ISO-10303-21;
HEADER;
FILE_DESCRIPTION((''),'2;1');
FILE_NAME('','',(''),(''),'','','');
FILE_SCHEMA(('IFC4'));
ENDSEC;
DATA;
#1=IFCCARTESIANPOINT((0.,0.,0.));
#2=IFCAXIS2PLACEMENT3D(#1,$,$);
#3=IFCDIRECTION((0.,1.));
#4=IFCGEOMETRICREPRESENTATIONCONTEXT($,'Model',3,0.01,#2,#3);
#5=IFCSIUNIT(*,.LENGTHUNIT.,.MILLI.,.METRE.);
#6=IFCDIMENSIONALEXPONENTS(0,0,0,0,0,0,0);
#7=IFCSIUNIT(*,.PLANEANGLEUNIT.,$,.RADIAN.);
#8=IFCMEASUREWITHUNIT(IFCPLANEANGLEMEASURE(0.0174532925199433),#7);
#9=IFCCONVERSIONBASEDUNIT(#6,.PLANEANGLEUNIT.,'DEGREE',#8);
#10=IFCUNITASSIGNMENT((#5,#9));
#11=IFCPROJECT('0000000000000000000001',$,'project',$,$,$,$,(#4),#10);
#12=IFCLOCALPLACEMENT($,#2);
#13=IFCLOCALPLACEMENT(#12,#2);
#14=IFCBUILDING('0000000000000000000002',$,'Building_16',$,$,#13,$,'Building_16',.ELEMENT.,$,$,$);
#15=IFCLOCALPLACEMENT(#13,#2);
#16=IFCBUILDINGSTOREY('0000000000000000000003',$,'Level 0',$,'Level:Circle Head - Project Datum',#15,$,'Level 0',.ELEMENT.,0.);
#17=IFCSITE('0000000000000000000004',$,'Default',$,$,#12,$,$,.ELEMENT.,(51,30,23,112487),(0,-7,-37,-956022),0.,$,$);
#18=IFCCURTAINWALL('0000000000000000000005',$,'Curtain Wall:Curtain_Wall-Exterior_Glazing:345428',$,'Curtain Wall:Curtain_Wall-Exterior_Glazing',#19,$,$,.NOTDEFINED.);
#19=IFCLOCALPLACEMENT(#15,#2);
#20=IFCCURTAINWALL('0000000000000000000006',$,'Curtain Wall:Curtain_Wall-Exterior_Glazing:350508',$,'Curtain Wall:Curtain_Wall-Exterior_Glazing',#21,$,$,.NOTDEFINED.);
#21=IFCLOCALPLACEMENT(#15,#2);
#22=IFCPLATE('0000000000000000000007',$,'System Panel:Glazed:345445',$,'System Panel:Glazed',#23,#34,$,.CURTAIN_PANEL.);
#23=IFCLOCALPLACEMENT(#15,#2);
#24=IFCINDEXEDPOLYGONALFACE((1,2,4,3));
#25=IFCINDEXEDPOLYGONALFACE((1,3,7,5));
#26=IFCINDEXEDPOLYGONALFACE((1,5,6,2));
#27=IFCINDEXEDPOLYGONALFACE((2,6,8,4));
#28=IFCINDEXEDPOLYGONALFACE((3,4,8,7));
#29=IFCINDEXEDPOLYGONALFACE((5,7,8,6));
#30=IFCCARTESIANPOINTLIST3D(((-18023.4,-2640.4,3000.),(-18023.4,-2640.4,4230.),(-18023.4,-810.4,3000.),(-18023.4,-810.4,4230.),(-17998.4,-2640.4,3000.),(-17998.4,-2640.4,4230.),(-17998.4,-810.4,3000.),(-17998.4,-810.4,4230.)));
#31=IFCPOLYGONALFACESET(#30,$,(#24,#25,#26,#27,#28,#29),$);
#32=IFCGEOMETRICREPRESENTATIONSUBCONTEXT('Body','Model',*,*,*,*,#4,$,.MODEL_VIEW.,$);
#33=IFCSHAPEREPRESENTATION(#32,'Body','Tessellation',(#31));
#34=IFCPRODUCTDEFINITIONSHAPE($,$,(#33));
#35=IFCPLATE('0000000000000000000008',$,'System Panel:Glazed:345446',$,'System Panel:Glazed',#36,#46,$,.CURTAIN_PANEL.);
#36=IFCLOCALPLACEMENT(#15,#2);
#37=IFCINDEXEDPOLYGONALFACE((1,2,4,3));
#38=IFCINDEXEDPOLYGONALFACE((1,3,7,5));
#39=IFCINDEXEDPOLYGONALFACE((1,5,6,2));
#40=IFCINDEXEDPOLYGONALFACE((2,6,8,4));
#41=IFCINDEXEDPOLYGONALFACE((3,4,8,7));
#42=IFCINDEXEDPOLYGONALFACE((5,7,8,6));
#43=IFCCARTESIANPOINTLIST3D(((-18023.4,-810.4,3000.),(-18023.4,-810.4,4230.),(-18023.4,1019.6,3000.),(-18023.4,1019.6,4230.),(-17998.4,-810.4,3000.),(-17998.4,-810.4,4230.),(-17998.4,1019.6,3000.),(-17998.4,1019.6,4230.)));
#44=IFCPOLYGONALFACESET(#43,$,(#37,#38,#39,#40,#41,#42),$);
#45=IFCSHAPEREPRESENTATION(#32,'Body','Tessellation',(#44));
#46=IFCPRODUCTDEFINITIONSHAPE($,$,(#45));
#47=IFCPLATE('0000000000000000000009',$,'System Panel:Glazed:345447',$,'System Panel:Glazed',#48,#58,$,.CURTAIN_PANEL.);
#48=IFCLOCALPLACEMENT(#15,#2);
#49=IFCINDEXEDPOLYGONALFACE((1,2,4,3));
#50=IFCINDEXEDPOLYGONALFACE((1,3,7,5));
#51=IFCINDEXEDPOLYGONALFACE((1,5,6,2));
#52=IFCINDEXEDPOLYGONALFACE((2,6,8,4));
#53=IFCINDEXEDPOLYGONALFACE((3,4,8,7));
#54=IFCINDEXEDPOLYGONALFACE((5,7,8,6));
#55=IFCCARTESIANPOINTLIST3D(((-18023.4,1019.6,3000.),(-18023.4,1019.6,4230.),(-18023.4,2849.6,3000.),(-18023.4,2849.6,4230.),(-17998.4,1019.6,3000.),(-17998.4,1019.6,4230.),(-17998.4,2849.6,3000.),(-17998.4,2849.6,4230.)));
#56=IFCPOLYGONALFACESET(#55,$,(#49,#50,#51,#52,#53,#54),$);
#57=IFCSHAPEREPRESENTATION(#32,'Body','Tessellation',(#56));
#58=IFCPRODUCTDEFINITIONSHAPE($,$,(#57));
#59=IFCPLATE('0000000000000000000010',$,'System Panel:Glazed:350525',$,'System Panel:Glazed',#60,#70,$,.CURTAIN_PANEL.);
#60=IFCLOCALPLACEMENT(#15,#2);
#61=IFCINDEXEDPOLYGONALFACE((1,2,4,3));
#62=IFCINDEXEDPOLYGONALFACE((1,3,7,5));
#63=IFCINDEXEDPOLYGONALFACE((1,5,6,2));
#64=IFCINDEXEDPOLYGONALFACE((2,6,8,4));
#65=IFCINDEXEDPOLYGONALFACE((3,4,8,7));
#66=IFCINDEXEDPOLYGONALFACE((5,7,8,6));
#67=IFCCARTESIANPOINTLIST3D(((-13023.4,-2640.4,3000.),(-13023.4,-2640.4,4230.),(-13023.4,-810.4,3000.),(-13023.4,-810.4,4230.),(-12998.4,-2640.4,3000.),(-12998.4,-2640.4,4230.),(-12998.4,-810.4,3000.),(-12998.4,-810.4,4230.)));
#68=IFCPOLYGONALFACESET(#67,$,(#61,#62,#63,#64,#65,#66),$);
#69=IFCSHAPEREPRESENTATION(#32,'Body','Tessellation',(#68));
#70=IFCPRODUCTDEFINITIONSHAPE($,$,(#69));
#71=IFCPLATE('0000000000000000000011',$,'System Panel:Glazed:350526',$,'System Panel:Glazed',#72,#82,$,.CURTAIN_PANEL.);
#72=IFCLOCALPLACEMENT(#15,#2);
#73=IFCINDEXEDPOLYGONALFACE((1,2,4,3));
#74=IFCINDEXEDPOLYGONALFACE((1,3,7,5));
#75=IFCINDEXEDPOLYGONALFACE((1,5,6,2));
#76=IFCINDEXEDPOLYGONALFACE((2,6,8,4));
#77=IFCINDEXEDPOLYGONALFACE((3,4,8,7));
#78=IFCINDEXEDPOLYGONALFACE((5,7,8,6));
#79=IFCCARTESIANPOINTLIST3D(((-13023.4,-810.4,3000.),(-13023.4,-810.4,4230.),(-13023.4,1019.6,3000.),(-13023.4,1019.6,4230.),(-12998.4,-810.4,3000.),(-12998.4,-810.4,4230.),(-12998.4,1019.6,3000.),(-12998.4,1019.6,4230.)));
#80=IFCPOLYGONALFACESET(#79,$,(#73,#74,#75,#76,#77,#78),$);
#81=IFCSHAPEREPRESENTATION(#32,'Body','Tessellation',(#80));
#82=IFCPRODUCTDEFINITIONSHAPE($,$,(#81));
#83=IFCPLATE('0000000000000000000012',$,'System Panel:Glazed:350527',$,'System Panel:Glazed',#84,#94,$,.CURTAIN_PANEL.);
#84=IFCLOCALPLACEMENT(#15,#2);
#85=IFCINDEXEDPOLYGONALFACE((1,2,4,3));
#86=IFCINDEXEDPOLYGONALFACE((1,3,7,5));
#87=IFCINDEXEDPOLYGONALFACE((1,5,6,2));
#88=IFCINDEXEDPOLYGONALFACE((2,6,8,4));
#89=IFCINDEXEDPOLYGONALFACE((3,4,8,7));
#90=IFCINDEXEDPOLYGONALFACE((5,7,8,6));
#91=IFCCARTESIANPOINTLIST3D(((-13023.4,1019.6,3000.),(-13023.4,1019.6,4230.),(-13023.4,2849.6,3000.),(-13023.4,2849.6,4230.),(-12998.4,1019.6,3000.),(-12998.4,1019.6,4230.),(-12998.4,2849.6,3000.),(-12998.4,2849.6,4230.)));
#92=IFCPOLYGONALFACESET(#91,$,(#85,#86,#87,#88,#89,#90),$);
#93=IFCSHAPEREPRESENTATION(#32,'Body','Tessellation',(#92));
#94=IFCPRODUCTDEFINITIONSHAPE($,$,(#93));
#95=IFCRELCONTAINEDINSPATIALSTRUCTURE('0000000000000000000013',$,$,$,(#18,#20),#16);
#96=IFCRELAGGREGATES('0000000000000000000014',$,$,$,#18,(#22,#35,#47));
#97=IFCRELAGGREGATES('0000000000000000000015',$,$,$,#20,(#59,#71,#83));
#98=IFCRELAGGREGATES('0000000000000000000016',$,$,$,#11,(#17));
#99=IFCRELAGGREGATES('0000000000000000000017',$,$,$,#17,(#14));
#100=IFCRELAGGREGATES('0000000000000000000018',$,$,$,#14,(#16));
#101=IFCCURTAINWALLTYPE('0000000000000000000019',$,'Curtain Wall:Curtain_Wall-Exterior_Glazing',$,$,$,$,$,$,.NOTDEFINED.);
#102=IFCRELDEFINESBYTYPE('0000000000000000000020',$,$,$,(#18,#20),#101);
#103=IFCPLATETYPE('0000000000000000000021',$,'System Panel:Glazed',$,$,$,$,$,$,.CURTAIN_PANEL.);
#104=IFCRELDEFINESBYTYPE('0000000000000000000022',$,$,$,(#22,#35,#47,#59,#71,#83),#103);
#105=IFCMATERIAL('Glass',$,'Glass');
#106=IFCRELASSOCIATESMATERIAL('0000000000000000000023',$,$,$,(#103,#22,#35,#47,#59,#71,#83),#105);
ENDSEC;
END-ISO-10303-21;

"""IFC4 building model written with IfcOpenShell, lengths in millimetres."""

from ifc_helpers import new_model, entity, si_unit, converted_unit, direction, frame, origin, place, context, subcontext, project, spatial, indexed_curve, outline, extrude, source, transform, mapped, material, type_object, type_shapes, element, aggregate, save


model = new_model("IFC4")

# Units and contexts
model_context = context("Model", 3, precision=0.01, world=origin(), true_north=direction((0.0, 1.0)))
body_context = subcontext(model_context, "Body", "Model", "MODEL_VIEW")
ifc_project = project(units=[si_unit("LENGTHUNIT", "METRE", prefix="MILLI"), converted_unit("PLANEANGLEUNIT", "DEGREE", entity("IfcPlaneAngleMeasure", 0.0174532925199433), si_unit("PLANEANGLEUNIT", "RADIAN"), dimensions=[0, 0, 0, 0, 0, 0, 0])], contexts=[model_context])

# Site, building, storey
site_placement = place(None, origin())
site = spatial("IfcSite", under=ifc_project, at=site_placement, Name="Default", CompositionType="ELEMENT", RefLatitude=(51, 30, 23, 112487), RefLongitude=(0, -7, -37, -956022), RefElevation=0.0)
building_placement = place(site_placement, origin())
building = spatial("IfcBuilding", under=site, at=building_placement, Name="Building_16", LongName="Building_16", CompositionType="ELEMENT")
storey_placement = place(building_placement, origin())
storey = spatial("IfcBuildingStorey", under=building, at=storey_placement, Name="Level 0", ObjectType="Level:Circle Head - Project Datum", LongName="Level 0", CompositionType="ELEMENT", Elevation=0.0)

# Curtain walls
curtain_wall_type = type_object("IfcCurtainWallType", Name="Curtain Wall:Curtain_Wall-Exterior_Glazing", PredefinedType="NOTDEFINED")
curtain_wall_1_placement = place(storey_placement, origin())
curtain_wall_1 = element("IfcCurtainWall", 1, at=curtain_wall_1_placement, inside=storey, type_object=curtain_wall_type, Name="Curtain Wall:Curtain_Wall-Exterior_Glazing:345428", ObjectType="Curtain Wall:Curtain_Wall-Exterior_Glazing", PredefinedType="NOTDEFINED")
ifc_material = material(Name="Glass", Category="Glass")
curtain_wall_2_placement = place(storey_placement, origin())
curtain_wall_2 = element("IfcCurtainWall", 2, at=curtain_wall_2_placement, inside=storey, type_object=curtain_wall_type, Name="Curtain Wall:Curtain_Wall-Exterior_Glazing:350508", ObjectType="Curtain Wall:Curtain_Wall-Exterior_Glazing", PredefinedType="NOTDEFINED")

# Plates
plate_type_1 = type_object("IfcPlateType", Name="System Panel:Glazed", PredefinedType="CURTAIN_PANEL", material=ifc_material)
shared_shape_1 = source(origin(), body_context, "Body", "SweptSolid", [
    extrude(outline(indexed_curve([(-12.5, -915.0), (12.5, -915.0), (12.5, 915.0), (-12.5, 915.0), (-12.5, -915.0)], self_intersect=False)), frame((0.0, 37.0, 0.0), z_axis=(0.0, 0.0, 1.0), x_axis=(0.0, 1.0, 0.0)), (0.0, 0.0, 1.0), 1230.0),
])
type_shapes(plate_type_1, [shared_shape_1])
plate_1_placement = place(curtain_wall_1_placement, frame((-17973.9, -1725.4, 3000.0), z_axis=(0.0, 0.0, 1.0), x_axis=(0.0, 1.0, 0.0)))
plate_1 = element("IfcPlate", 3, at=plate_1_placement, type_object=plate_type_1, material=ifc_material, Name="System Panel:Glazed:345445", ObjectType="System Panel:Glazed", PredefinedType="CURTAIN_PANEL", context=body_context, shape_type="MappedRepresentation", body=[
    mapped(shared_shape_1, transform((0.0, 0.0, 0.0), scale=1.0)),
])
plate_2_placement = place(curtain_wall_1_placement, frame((-17973.9, 104.6, 3000.0), z_axis=(0.0, 0.0, 1.0), x_axis=(0.0, 1.0, 0.0)))
plate_2 = element("IfcPlate", 4, at=plate_2_placement, type_object=plate_type_1, material=ifc_material, Name="System Panel:Glazed:345446", ObjectType="System Panel:Glazed", PredefinedType="CURTAIN_PANEL", context=body_context, shape_type="MappedRepresentation", body=[
    mapped(shared_shape_1, transform((0.0, 0.0, 0.0), scale=1.0)),
])
plate_3_placement = place(curtain_wall_1_placement, frame((-17973.9, 1934.6, 3000.0), z_axis=(0.0, 0.0, 1.0), x_axis=(0.0, 1.0, 0.0)))
plate_3 = element("IfcPlate", 5, at=plate_3_placement, type_object=plate_type_1, material=ifc_material, Name="System Panel:Glazed:345447", ObjectType="System Panel:Glazed", PredefinedType="CURTAIN_PANEL", context=body_context, shape_type="MappedRepresentation", body=[
    mapped(shared_shape_1, transform((0.0, 0.0, 0.0), scale=1.0)),
])
aggregate(curtain_wall_1, [plate_1, plate_2, plate_3])
plate_4_placement = place(curtain_wall_2_placement, frame((-12973.9, -1725.4, 3000.0), z_axis=(0.0, 0.0, 1.0), x_axis=(0.0, 1.0, 0.0)))
plate_4 = element("IfcPlate", 6, at=plate_4_placement, type_object=plate_type_1, material=ifc_material, Name="System Panel:Glazed:350525", ObjectType="System Panel:Glazed", PredefinedType="CURTAIN_PANEL", context=body_context, shape_type="MappedRepresentation", body=[
    mapped(shared_shape_1, transform((0.0, 0.0, 0.0), scale=1.0)),
])
plate_5_placement = place(curtain_wall_2_placement, frame((-12973.9, 104.6, 3000.0), z_axis=(0.0, 0.0, 1.0), x_axis=(0.0, 1.0, 0.0)))
plate_5 = element("IfcPlate", 7, at=plate_5_placement, type_object=plate_type_1, material=ifc_material, Name="System Panel:Glazed:350526", ObjectType="System Panel:Glazed", PredefinedType="CURTAIN_PANEL", context=body_context, shape_type="MappedRepresentation", body=[
    mapped(shared_shape_1, transform((0.0, 0.0, 0.0), scale=1.0)),
])
plate_6_placement = place(curtain_wall_2_placement, frame((-12973.9, 1934.6, 3000.0), z_axis=(0.0, 0.0, 1.0), x_axis=(0.0, 1.0, 0.0)))
plate_6 = element("IfcPlate", 8, at=plate_6_placement, type_object=plate_type_1, material=ifc_material, Name="System Panel:Glazed:350527", ObjectType="System Panel:Glazed", PredefinedType="CURTAIN_PANEL", context=body_context, shape_type="MappedRepresentation", body=[
    mapped(shared_shape_1, transform((0.0, 0.0, 0.0), scale=1.0)),
])
aggregate(curtain_wall_2, [plate_4, plate_5, plate_6])

save(model, "model.ifc")
